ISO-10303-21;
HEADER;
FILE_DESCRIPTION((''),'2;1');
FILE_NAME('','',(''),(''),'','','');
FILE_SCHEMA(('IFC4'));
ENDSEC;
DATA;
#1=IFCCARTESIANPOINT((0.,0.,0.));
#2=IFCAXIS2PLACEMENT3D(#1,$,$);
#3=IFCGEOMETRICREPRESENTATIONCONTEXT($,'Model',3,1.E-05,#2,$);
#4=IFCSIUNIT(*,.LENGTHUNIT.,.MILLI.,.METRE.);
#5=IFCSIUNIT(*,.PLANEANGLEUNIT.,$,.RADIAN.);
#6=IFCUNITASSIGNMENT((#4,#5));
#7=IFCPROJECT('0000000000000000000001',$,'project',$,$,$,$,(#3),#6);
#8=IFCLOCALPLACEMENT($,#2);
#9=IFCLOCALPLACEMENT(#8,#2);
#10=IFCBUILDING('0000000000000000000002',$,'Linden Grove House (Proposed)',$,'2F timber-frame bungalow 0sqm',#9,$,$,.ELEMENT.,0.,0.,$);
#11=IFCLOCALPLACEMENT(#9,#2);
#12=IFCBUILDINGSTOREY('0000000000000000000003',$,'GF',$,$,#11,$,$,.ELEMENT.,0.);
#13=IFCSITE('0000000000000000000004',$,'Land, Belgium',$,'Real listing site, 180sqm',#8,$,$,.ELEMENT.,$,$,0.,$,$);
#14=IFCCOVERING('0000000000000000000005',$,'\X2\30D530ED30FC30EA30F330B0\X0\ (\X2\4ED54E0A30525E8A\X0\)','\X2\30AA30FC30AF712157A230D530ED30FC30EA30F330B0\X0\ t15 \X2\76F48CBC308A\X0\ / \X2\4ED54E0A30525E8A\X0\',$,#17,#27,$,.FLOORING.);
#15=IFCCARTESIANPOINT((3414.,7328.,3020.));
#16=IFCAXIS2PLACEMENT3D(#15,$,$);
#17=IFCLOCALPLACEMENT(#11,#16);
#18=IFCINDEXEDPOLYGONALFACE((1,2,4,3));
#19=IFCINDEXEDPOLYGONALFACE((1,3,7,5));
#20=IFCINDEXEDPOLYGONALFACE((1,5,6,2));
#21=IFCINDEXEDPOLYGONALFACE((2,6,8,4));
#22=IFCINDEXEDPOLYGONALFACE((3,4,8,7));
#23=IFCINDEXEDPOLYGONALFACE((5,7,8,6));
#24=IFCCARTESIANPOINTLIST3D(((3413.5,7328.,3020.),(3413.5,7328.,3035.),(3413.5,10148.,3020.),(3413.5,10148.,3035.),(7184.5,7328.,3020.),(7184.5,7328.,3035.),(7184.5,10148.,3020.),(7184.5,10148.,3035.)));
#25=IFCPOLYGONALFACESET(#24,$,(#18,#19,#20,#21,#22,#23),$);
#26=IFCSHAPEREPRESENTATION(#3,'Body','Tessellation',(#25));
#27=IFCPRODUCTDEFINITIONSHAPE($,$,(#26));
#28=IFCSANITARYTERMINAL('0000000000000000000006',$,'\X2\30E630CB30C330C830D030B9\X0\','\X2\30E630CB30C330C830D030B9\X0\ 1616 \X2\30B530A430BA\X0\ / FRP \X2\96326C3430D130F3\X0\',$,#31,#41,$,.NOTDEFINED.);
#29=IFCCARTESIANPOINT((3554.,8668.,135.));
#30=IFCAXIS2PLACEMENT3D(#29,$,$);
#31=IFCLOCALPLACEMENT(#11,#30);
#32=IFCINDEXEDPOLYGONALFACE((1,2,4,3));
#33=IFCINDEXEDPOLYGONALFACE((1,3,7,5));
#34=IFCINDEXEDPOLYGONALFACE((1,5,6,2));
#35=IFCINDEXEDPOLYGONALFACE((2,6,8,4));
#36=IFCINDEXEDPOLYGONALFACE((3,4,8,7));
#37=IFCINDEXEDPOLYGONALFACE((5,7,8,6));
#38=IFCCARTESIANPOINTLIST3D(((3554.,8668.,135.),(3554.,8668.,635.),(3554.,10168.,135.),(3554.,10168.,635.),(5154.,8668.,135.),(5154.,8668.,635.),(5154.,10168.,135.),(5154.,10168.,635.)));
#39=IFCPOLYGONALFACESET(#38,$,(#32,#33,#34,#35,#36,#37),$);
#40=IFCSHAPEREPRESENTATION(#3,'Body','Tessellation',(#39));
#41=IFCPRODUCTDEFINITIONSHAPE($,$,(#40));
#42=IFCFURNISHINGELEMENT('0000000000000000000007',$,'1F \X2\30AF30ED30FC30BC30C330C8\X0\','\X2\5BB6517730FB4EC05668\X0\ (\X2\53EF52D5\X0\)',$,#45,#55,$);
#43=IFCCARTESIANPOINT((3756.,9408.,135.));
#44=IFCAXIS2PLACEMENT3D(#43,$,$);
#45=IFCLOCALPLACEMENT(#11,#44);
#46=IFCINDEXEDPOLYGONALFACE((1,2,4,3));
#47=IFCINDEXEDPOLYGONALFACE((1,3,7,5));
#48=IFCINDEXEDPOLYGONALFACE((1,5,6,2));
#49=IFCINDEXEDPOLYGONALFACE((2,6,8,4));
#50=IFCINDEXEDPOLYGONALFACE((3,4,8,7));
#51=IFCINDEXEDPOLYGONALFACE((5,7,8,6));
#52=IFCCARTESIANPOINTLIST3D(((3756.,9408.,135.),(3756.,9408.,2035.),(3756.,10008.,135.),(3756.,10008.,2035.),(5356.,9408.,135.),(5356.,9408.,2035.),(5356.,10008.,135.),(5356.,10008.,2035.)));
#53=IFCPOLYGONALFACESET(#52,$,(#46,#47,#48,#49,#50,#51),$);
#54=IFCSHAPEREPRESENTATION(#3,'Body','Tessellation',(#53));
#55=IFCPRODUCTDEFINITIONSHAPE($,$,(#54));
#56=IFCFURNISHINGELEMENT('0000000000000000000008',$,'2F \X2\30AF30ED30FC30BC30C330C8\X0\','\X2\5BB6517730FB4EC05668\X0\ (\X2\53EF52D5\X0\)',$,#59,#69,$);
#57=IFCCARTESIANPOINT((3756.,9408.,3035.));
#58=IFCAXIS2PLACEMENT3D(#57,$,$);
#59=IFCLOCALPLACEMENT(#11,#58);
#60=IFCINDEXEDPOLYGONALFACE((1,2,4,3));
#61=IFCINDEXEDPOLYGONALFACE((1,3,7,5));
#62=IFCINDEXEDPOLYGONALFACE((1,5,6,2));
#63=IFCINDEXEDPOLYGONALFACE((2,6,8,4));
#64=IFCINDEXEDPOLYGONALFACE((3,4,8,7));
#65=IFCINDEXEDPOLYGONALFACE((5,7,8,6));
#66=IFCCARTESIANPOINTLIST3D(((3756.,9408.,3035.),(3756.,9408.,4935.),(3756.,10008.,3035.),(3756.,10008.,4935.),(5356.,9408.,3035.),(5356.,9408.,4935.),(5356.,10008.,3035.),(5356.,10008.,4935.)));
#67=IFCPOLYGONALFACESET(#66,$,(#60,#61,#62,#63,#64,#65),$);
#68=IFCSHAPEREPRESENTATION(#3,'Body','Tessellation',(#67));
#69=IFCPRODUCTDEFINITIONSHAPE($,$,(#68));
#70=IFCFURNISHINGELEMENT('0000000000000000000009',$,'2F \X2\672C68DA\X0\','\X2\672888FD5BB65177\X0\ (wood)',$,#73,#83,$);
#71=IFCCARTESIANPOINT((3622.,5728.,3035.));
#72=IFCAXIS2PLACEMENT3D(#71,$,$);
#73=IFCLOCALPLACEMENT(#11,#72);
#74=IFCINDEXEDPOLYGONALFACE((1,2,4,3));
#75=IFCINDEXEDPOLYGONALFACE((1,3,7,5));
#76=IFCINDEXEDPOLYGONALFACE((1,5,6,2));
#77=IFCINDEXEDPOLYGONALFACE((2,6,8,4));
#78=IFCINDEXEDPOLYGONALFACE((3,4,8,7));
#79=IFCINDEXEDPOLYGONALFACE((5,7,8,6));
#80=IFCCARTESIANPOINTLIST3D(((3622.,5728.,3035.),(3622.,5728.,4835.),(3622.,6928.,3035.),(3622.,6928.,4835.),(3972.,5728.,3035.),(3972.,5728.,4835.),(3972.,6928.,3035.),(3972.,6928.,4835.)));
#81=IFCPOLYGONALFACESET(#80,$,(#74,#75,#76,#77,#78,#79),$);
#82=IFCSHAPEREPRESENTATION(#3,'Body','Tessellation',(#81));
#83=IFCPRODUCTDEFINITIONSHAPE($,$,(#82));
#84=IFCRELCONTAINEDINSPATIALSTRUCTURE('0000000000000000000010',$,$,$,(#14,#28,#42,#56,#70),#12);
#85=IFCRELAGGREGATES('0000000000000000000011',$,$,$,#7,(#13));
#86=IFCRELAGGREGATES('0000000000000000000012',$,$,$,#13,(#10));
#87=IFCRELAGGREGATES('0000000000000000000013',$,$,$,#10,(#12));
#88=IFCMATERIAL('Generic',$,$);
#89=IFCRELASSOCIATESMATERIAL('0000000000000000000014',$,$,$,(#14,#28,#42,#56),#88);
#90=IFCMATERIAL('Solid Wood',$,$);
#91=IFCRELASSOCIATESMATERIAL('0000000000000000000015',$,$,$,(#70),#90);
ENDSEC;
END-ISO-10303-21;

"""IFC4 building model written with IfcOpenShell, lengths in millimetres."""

from ifc_helpers import new_model, si_unit, frame, frame_2d, origin, place, context, project, spatial, rectangle, extrude, material, element, save


model = new_model("IFC4")

# Units and contexts
model_context = context("Model", 3, precision=1e-05, world=origin())
ifc_project = project(units=[si_unit("LENGTHUNIT", "METRE", prefix="MILLI"), si_unit("PLANEANGLEUNIT", "RADIAN")], contexts=[model_context])

# Site, building, storey
site_placement = place(None, origin())
site = spatial("IfcSite", under=ifc_project, at=site_placement, Name="Land, Belgium", ObjectType="Real listing site, 180sqm", CompositionType="ELEMENT", RefElevation=0.0)
building_placement = place(site_placement, origin())
building = spatial("IfcBuilding", under=site, at=building_placement, Name="Linden Grove House (Proposed)", ObjectType="2F timber-frame bungalow 0sqm", CompositionType="ELEMENT", ElevationOfRefHeight=0.0, ElevationOfTerrain=0.0)
storey_placement = place(building_placement, origin())
storey = spatial("IfcBuildingStorey", under=building, at=storey_placement, Name="GF", CompositionType="ELEMENT", Elevation=0.0)

# Shared definitions
ifc_material_1 = material(Name="Solid Wood")

# Covering
ifc_material_2 = material(Name="Generic")
covering_1_placement = place(storey_placement, frame((3414.0, 7328.0, 3020.0)))
element("IfcCovering", 1, at=covering_1_placement, inside=storey, material=ifc_material_2, Name="フローリング (仕上げ床)", Description="オーク無垢フローリング t15 直貼り / 仕上げ床", PredefinedType="FLOORING", context=model_context, shape_type="SweptSolid", body=[
    extrude(rectangle(XDim=3771.0, YDim=2820.0, at=frame_2d((1885.0, 1410.0))), frame((3414.0, 7328.0, 3020.0)), (0.0, 0.0, 1.0), 15.0),
])

# Sanitary terminal
sanitary_terminal_placement = place(storey_placement, frame((3554.0, 8668.0, 135.0)))
element("IfcSanitaryTerminal", 2, at=sanitary_terminal_placement, inside=storey, material=ifc_material_2, Name="ユニットバス", Description="ユニットバス 1616 サイズ / FRP 防水パン", PredefinedType="NOTDEFINED", context=model_context, shape_type="SweptSolid", body=[
    extrude(rectangle(XDim=1600.0, YDim=1500.0, at=frame_2d((800.0, 750.0))), frame((3554.0, 8668.0, 135.0)), (0.0, 0.0, 1.0), 500.0),
])

# Furnishing elements
furnishing_1_placement = place(storey_placement, frame((3756.0, 9408.0, 135.0)))
element("IfcFurnishingElement", 3, at=furnishing_1_placement, inside=storey, material=ifc_material_2, Name="1F クローゼット", Description="家具・什器 (可動)", context=model_context, shape_type="SweptSolid", body=[
    extrude(rectangle(XDim=1600.0, YDim=600.0, at=frame_2d((800.0, 300.0))), frame((3756.0, 9408.0, 135.0)), (0.0, 0.0, 1.0), 1900.0),
])
furnishing_2_placement = place(storey_placement, frame((3756.0, 9408.0, 3035.0)))
element("IfcFurnishingElement", 4, at=furnishing_2_placement, inside=storey, material=ifc_material_2, Name="2F クローゼット", Description="家具・什器 (可動)", context=model_context, shape_type="SweptSolid", body=[
    extrude(rectangle(XDim=1600.0, YDim=600.0, at=frame_2d((800.0, 300.0))), frame((3756.0, 9408.0, 3035.0)), (0.0, 0.0, 1.0), 1900.0),
])
furnishing_3_placement = place(storey_placement, frame((3622.0, 5728.0, 3035.0)))
element("IfcFurnishingElement", 5, at=furnishing_3_placement, inside=storey, material=ifc_material_1, Name="2F 本棚", Description="木製家具 (wood)", context=model_context, shape_type="SweptSolid", body=[
    extrude(rectangle(XDim=350.0, YDim=1200.0, at=frame_2d((175.0, 600.0))), frame((3622.0, 5728.0, 3035.0)), (0.0, 0.0, 1.0), 1800.0),
])

save(model, "model.ifc")
